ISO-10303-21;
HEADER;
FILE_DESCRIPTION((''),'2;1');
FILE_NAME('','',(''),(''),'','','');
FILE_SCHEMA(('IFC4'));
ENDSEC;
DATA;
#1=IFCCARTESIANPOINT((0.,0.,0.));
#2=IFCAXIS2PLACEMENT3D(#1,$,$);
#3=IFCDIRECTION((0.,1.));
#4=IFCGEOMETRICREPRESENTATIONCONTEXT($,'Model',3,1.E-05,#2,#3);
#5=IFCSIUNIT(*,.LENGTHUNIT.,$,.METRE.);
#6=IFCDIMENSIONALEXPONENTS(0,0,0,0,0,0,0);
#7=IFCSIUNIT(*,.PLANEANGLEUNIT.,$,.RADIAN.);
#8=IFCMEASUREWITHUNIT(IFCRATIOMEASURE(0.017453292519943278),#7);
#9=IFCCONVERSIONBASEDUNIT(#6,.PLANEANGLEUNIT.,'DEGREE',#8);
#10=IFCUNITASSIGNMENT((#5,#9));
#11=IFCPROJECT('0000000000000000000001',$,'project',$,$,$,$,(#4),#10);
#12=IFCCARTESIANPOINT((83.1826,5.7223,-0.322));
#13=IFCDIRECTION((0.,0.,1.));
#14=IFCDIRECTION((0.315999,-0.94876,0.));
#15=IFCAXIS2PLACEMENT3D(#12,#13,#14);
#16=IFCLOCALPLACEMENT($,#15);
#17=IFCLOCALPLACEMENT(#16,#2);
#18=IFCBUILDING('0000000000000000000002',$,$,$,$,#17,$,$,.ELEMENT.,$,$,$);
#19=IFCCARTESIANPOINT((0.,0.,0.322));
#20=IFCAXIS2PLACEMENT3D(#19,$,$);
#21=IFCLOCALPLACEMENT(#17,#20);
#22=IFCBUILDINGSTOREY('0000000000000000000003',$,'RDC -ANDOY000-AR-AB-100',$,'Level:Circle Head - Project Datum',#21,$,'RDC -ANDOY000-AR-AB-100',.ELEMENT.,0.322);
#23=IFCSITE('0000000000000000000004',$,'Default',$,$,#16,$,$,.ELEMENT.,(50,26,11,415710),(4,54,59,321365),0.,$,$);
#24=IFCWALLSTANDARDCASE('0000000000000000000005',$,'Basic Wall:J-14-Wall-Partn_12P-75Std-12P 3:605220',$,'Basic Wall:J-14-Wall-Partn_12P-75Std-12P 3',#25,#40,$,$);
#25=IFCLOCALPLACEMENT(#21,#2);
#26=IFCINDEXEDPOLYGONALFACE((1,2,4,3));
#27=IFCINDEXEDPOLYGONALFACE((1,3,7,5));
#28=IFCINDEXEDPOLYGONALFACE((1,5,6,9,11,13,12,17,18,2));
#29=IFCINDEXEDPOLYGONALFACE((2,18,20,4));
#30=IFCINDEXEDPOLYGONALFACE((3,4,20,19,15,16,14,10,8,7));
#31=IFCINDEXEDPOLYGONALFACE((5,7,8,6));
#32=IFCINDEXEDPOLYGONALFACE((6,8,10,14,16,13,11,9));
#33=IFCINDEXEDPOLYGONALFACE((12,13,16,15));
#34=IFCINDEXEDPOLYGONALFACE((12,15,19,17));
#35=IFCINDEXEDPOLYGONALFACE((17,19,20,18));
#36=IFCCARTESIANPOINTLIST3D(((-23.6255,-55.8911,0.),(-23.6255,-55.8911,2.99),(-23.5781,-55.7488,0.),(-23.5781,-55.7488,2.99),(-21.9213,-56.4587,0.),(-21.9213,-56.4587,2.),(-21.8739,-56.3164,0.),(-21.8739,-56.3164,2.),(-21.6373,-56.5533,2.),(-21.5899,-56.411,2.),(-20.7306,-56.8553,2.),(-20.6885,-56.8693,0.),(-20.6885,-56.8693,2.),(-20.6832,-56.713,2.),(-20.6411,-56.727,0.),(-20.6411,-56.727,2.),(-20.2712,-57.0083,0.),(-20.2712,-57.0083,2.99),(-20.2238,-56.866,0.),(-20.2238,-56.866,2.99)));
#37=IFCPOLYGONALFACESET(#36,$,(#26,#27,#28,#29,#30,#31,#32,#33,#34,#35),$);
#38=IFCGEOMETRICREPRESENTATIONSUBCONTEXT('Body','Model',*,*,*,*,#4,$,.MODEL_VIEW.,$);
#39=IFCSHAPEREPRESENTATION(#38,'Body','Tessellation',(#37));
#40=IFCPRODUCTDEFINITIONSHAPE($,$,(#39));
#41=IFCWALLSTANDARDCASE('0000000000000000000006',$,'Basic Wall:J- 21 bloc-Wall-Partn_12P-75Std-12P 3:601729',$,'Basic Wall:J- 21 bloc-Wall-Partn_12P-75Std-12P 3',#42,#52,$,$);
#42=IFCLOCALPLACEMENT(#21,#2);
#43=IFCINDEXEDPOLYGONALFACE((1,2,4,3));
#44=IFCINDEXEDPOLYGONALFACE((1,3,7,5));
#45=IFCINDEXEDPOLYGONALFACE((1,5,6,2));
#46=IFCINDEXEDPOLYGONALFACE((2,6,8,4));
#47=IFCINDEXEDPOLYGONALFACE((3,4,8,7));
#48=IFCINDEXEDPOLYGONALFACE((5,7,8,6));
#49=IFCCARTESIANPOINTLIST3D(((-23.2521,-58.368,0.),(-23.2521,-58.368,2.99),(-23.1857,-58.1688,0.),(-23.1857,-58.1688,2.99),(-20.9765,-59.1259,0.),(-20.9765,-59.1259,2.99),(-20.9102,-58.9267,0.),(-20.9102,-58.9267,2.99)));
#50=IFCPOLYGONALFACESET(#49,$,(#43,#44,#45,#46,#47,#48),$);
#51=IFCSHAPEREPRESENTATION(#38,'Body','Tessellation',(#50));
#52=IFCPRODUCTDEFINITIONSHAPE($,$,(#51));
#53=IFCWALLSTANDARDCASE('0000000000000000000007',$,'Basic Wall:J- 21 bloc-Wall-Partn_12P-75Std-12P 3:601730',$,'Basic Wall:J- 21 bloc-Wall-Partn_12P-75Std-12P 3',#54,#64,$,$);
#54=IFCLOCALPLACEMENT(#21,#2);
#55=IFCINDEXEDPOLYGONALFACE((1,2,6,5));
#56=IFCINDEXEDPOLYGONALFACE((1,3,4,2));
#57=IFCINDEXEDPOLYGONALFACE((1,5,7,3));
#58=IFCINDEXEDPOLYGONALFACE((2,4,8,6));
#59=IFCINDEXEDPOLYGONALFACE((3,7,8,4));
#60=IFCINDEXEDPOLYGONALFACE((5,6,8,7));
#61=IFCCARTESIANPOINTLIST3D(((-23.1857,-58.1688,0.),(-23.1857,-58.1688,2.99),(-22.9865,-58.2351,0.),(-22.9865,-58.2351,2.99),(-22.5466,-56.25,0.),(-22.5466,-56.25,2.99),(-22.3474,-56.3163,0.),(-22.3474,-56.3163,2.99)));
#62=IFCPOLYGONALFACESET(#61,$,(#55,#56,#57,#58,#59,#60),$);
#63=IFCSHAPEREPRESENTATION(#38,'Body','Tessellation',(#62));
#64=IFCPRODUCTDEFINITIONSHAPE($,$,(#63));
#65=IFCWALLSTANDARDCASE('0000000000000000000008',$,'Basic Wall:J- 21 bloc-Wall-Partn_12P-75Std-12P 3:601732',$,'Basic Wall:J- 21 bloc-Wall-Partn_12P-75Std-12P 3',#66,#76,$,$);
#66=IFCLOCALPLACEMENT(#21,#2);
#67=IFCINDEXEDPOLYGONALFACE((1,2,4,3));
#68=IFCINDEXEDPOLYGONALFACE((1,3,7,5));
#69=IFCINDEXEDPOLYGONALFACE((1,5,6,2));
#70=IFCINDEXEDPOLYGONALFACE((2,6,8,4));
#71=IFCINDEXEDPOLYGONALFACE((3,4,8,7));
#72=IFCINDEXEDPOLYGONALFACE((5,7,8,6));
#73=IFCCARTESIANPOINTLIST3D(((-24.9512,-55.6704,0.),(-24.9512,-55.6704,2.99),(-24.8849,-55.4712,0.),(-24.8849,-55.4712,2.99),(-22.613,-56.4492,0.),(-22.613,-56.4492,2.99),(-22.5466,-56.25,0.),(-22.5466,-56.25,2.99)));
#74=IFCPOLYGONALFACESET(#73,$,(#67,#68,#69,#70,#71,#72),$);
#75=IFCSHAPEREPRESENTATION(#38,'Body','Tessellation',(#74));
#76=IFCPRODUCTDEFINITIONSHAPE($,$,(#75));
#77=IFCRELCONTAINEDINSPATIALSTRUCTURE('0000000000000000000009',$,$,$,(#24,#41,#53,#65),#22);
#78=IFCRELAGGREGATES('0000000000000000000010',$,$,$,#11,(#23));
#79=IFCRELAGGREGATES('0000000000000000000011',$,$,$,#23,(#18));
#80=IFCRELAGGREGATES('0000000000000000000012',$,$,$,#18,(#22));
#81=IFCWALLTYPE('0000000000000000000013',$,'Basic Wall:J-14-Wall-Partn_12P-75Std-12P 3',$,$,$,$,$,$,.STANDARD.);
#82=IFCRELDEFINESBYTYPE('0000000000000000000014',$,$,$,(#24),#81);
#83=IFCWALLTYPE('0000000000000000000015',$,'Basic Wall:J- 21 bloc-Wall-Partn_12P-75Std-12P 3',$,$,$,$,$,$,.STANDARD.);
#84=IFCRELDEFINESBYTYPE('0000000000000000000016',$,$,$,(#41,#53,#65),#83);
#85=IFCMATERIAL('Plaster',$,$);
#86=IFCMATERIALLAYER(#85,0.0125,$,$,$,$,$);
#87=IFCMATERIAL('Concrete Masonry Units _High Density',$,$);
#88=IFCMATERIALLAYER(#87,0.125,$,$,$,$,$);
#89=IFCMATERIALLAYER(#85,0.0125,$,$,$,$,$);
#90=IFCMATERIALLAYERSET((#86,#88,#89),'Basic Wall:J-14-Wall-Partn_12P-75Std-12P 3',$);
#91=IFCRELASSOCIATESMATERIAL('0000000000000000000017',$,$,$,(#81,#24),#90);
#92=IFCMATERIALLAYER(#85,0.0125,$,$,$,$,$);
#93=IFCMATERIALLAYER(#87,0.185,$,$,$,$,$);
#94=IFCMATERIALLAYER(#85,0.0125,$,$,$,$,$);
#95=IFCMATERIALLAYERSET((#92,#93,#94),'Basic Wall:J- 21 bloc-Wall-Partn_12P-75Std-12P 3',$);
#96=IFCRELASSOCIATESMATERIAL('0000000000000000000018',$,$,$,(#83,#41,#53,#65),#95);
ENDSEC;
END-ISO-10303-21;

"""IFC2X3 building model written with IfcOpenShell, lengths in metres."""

from ifc_helpers import new_model, entity, si_unit, converted_unit, direction, frame, frame_2d, origin, place, context, subcontext, project, spatial, polyline, rectangle, extrude, clip, bounded_halfspace, material, layer, layer_set, layer_usage, type_object, element, save


model = new_model("IFC2X3")

# Units and contexts
model_context = context("Model", 3, precision=1e-05, world=origin(), true_north=direction((0.0, 1.0)))
body_context = subcontext(model_context, "Body", "Model", "MODEL_VIEW")
ifc_project = project(units=[si_unit("LENGTHUNIT", "METRE"), converted_unit("PLANEANGLEUNIT", "DEGREE", entity("IfcRatioMeasure", 0.017453292519943278), si_unit("PLANEANGLEUNIT", "RADIAN"), dimensions=[0, 0, 0, 0, 0, 0, 0])], contexts=[model_context])

# Site, building, storey
site_placement = place(None, frame((83.1826, 5.7223, -0.322), z_axis=(0.0, 0.0, 1.0), x_axis=(0.315999, -0.94876, 0.0)))
site = spatial("IfcSite", under=ifc_project, at=site_placement, Name="Default", CompositionType="ELEMENT", RefLatitude=(50, 26, 11, 415710), RefLongitude=(4, 54, 59, 321365), RefElevation=0.0)
building_placement = place(site_placement, origin())
building = spatial("IfcBuilding", under=site, at=building_placement, CompositionType="ELEMENT")
storey_placement = place(building_placement, frame((0.0, 0.0, 0.322)))
storey = spatial("IfcBuildingStorey", under=building, at=storey_placement, Name="RDC -ANDOY000-AR-AB-100", ObjectType="Level:Circle Head - Project Datum", LongName="RDC -ANDOY000-AR-AB-100", CompositionType="ELEMENT", Elevation=0.322)

# Shared definitions
ifc_material_1 = material(Name="Plaster")

# Shared definitions
ifc_material_2 = material(Name="Concrete Masonry Units _High Density")

# Wall, openings
ifc_layer_1 = layer(ifc_material_1, 0.0125)
ifc_layer_2 = layer(ifc_material_2, 0.125)
ifc_layer_3 = layer(ifc_material_1, 0.0125)
ifc_layer_set_1 = layer_set([ifc_layer_1, ifc_layer_2, ifc_layer_3], Name="Basic Wall:J-14-Wall-Partn_12P-75Std-12P 3")
ifc_layer_usage_1 = layer_usage(ifc_layer_set_1, "AXIS2", "NEGATIVE", 0.075)
wall_type_1 = type_object("IfcWallType", Name="Basic Wall:J-14-Wall-Partn_12P-75Std-12P 3", PredefinedType="STANDARD", material=ifc_layer_set_1)
wall_1_placement = place(storey_placement, frame((-23.6018, -55.8199, 0.0), z_axis=(0.0, 0.0, 1.0), x_axis=(0.948759, -0.316, 0.0)))
wall_1 = element("IfcWallStandardCase", 1, at=wall_1_placement, inside=storey, type_object=wall_type_1, material=ifc_layer_usage_1, Name="Basic Wall:J-14-Wall-Partn_12P-75Std-12P 3:605220", ObjectType="Basic Wall:J-14-Wall-Partn_12P-75Std-12P 3", context=body_context, shape_type="Clipping", body=[
    clip(extrude(rectangle(XDim=3.5355, YDim=0.15, at=frame_2d((1.7677, 0.0), x_axis=(-1.0, 0.0))), origin(), (0.0, 0.0, 1.0), 2.99), bounded_halfspace(frame((0.0, -0.075, 2.99), z_axis=(0.0, 0.0, -1.0), x_axis=(1.0, 0.0, 0.0)), True, frame((0.0, -0.075, 2.99)), polyline([(0.0, 0.0), (3.5355, 0.0), (3.5355, 0.15), (0.0, 0.15), (0.0, 0.0)]))),
])
opening_1_placement = place(wall_1_placement, origin())
element("IfcOpeningElement", 2, at=opening_1_placement, cuts=wall_1, ObjectType="Opening", context=body_context, shape_type="SweptSolid", body=[
    extrude(rectangle(XDim=2.0, YDim=1.0, at=frame_2d((0.0, 0.0), x_axis=(1.0, 0.0))), frame((2.5956, -0.075, 1.0), z_axis=(0.0, 1.0, 0.0), x_axis=(0.0, 0.0, -1.0)), (0.0, 0.0, 1.0), 0.15),
])
opening_2_placement = place(wall_1_placement, origin())
element("IfcOpeningElement", 3, at=opening_2_placement, cuts=wall_1, ObjectType="Opening", context=body_context, shape_type="SweptSolid", body=[
    extrude(rectangle(XDim=2.0, YDim=1.255, at=frame_2d((0.0, 0.0), x_axis=(1.0, 0.0))), frame((2.4237, -1.599, 1.0), z_axis=(0.0, 1.0, 0.0), x_axis=(0.0, 0.0, 1.0)), (0.0, 0.0, 1.0), 3.048),
])

# Walls
ifc_layer_4 = layer(ifc_material_1, 0.0125)
ifc_layer_5 = layer(ifc_material_2, 0.185)
ifc_layer_6 = layer(ifc_material_1, 0.0125)
ifc_layer_set_2 = layer_set([ifc_layer_4, ifc_layer_5, ifc_layer_6], Name="Basic Wall:J- 21 bloc-Wall-Partn_12P-75Std-12P 3")
ifc_layer_usage_2 = layer_usage(ifc_layer_set_2, "AXIS2", "NEGATIVE", 0.105)
wall_type_2 = type_object("IfcWallType", Name="Basic Wall:J- 21 bloc-Wall-Partn_12P-75Std-12P 3", PredefinedType="STANDARD", material=ifc_layer_set_2)
wall_2_placement = place(storey_placement, frame((-20.9433, -59.0263, 0.0), z_axis=(0.0, 0.0, 1.0), x_axis=(-0.948759, 0.316, 0.0)))
element("IfcWallStandardCase", 4, at=wall_2_placement, inside=storey, type_object=wall_type_2, material=ifc_layer_usage_2, Name="Basic Wall:J- 21 bloc-Wall-Partn_12P-75Std-12P 3:601729", ObjectType="Basic Wall:J- 21 bloc-Wall-Partn_12P-75Std-12P 3", context=body_context, shape_type="Clipping", body=[
    clip(extrude(rectangle(XDim=2.3985, YDim=0.21, at=frame_2d((1.1992, 0.0), x_axis=(-1.0, 0.0))), origin(), (0.0, 0.0, 1.0), 2.99), bounded_halfspace(frame((0.0, -0.105, 2.99), z_axis=(0.0, 0.0, -1.0), x_axis=(-1.0, 0.0, 0.0)), True, frame((0.0, -0.105, 2.99)), polyline([(0.0, 0.0), (2.1885, 0.0), (2.3985, 0.0), (2.3985, 0.21), (1.7876, 0.21), (1.6876, 0.21), (0.0, 0.21), (0.0, 0.0)]))),
])
wall_3_placement = place(storey_placement, frame((-23.0861, -58.2019, 0.0), z_axis=(0.0, 0.0, 1.0), x_axis=(0.316, 0.948759, 0.0)))
element("IfcWallStandardCase", 5, at=wall_3_placement, inside=storey, type_object=wall_type_2, material=ifc_layer_usage_2, Name="Basic Wall:J- 21 bloc-Wall-Partn_12P-75Std-12P 3:601730", ObjectType="Basic Wall:J- 21 bloc-Wall-Partn_12P-75Std-12P 3", context=body_context, shape_type="Clipping", body=[
    clip(extrude(rectangle(XDim=2.0224, YDim=0.21, at=frame_2d((1.0112, 0.0), x_axis=(-1.0, 0.0))), origin(), (0.0, 0.0, 1.0), 2.99), bounded_halfspace(frame((0.0, -0.105, 2.99), z_axis=(0.0, 0.0, -1.0), x_axis=(0.0, -1.0, 0.0)), True, frame((0.0, -0.105, 2.99)), polyline([(0.0, 0.0), (2.0224, 0.0), (2.0224, 0.21), (1.8124, 0.21), (0.0, 0.21), (0.0, 0.0)]))),
])
wall_4_placement = place(storey_placement, frame((-24.9181, -55.5708, 0.0), z_axis=(0.0, 0.0, 1.0), x_axis=(0.948759, -0.316, 0.0)))
element("IfcWallStandardCase", 6, at=wall_4_placement, inside=storey, type_object=wall_type_2, material=ifc_layer_usage_2, Name="Basic Wall:J- 21 bloc-Wall-Partn_12P-75Std-12P 3:601732", ObjectType="Basic Wall:J- 21 bloc-Wall-Partn_12P-75Std-12P 3", context=body_context, shape_type="Clipping", body=[
    clip(extrude(rectangle(XDim=2.4645, YDim=0.21, at=frame_2d((1.2323, 0.0), x_axis=(-1.0, 0.0))), origin(), (0.0, 0.0, 1.0), 2.99), bounded_halfspace(frame((0.0, -0.105, 2.99), z_axis=(0.0, 0.0, -1.0), x_axis=(1.0, 0.0, 0.0)), True, frame((0.0, -0.105, 2.99)), polyline([(0.0, 0.0), (2.4645, 0.0), (2.4645, 0.21), (0.0, 0.21), (0.0, 0.0)]))),
])

save(model, "model.ifc")
